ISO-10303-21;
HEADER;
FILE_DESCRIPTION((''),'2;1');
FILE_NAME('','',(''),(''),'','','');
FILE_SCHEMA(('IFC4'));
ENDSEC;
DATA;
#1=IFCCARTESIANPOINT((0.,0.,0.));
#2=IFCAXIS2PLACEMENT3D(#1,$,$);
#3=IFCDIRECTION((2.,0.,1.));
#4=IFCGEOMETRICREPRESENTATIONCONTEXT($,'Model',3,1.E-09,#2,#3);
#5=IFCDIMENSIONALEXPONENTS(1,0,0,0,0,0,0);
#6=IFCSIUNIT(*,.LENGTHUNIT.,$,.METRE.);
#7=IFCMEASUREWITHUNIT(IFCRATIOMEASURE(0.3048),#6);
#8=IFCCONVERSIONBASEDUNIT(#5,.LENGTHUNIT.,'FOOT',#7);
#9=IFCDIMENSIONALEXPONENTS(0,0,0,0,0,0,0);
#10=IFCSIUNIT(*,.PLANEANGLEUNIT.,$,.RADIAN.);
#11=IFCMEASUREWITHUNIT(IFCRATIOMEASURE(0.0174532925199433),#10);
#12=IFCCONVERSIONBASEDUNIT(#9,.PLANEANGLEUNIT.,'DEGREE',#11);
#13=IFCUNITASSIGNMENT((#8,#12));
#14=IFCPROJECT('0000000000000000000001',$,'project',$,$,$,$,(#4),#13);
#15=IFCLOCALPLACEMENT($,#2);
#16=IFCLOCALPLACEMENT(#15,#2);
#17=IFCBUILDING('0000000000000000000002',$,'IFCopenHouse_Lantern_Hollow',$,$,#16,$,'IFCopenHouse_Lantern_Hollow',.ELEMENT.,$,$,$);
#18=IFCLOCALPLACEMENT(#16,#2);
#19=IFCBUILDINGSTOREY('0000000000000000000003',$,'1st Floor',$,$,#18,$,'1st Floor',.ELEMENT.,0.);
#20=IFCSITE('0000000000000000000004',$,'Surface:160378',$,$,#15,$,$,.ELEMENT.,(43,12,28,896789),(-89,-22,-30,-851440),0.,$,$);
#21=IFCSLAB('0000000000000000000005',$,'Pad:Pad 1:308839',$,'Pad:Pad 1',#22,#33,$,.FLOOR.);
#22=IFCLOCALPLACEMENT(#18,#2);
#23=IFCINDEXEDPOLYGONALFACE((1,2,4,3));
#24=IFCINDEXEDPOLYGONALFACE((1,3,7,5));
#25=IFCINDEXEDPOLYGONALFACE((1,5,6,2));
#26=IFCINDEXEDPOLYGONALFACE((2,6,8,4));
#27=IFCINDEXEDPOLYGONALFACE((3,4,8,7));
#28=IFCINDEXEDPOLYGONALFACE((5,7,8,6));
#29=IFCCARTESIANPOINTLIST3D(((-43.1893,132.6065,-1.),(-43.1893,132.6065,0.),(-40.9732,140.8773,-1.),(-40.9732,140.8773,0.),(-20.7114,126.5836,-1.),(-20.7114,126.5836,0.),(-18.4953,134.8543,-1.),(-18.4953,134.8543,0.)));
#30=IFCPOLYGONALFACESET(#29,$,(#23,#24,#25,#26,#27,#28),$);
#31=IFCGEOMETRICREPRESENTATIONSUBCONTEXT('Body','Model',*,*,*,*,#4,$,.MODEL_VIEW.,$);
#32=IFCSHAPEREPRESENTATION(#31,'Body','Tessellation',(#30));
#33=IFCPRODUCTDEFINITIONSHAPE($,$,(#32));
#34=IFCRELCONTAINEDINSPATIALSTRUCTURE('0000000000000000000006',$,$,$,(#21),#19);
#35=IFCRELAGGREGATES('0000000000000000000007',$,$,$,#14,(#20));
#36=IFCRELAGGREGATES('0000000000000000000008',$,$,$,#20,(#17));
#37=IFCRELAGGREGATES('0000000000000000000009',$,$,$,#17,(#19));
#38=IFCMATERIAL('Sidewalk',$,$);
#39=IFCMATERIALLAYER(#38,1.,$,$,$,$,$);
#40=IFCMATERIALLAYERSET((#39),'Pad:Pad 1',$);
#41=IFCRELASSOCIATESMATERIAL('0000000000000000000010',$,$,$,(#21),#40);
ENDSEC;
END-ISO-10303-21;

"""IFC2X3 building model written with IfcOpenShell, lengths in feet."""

from ifc_helpers import new_model, entity, si_unit, converted_unit, direction, frame, frame_2d, origin, place, context, subcontext, project, spatial, rectangle, extrude, material, layer, layer_set, layer_usage, element, save


model = new_model("IFC2X3")

# Units and contexts
model_context = context("Model", 3, precision=1e-09, world=origin(), true_north=direction((2.0, 0.0, 1.0)))
body_context = subcontext(model_context, "Body", "Model", "MODEL_VIEW")
ifc_project = project(units=[converted_unit("LENGTHUNIT", "FOOT", entity("IfcRatioMeasure", 0.3048), si_unit("LENGTHUNIT", "METRE"), dimensions=[1, 0, 0, 0, 0, 0, 0]), converted_unit("PLANEANGLEUNIT", "DEGREE", entity("IfcRatioMeasure", 0.0174532925199433), si_unit("PLANEANGLEUNIT", "RADIAN"), dimensions=[0, 0, 0, 0, 0, 0, 0])], contexts=[model_context])

# Site, building, storey
site_placement = place(None, origin())
site = spatial("IfcSite", under=ifc_project, at=site_placement, Name="Surface:160378", CompositionType="ELEMENT", RefLatitude=(43, 12, 28, 896789), RefLongitude=(-89, -22, -30, -851440), RefElevation=0.0)
building_placement = place(site_placement, origin())
building = spatial("IfcBuilding", under=site, at=building_placement, Name="IFCopenHouse_Lantern_Hollow", LongName="IFCopenHouse_Lantern_Hollow", CompositionType="ELEMENT")
storey_placement = place(building_placement, origin())
storey = spatial("IfcBuildingStorey", under=building, at=storey_placement, Name="1st Floor", LongName="1st Floor", CompositionType="ELEMENT", Elevation=0.0)

# Slab
ifc_material_1 = material(Name="Sidewalk")
ifc_layer_1 = layer(ifc_material_1, 1.0)
ifc_layer_set_1 = layer_set([ifc_layer_1], Name="Pad:Pad 1")
ifc_layer_usage_1 = layer_usage(ifc_layer_set_1, "AXIS3", "NEGATIVE", 0.0)
slab_1_placement = place(storey_placement, frame((-43.1893, 126.5836, -1.0)))
element("IfcSlab", 1, at=slab_1_placement, inside=storey, material=ifc_layer_usage_1, Name="Pad:Pad 1:308839", ObjectType="Pad:Pad 1", PredefinedType="FLOOR", context=body_context, shape_type="SweptSolid", body=[
    extrude(rectangle(XDim=23.2708, YDim=8.5625, at=frame_2d((0.0, 0.0), x_axis=(0.965926, 0.258819))), frame((12.347, 7.1468, 1.0), z_axis=(0.0, 0.0, -1.0), x_axis=(-1.0, 0.0, 0.0)), (0.0, 0.0, 1.0), 1.0),
])

save(model, "model.ifc")
